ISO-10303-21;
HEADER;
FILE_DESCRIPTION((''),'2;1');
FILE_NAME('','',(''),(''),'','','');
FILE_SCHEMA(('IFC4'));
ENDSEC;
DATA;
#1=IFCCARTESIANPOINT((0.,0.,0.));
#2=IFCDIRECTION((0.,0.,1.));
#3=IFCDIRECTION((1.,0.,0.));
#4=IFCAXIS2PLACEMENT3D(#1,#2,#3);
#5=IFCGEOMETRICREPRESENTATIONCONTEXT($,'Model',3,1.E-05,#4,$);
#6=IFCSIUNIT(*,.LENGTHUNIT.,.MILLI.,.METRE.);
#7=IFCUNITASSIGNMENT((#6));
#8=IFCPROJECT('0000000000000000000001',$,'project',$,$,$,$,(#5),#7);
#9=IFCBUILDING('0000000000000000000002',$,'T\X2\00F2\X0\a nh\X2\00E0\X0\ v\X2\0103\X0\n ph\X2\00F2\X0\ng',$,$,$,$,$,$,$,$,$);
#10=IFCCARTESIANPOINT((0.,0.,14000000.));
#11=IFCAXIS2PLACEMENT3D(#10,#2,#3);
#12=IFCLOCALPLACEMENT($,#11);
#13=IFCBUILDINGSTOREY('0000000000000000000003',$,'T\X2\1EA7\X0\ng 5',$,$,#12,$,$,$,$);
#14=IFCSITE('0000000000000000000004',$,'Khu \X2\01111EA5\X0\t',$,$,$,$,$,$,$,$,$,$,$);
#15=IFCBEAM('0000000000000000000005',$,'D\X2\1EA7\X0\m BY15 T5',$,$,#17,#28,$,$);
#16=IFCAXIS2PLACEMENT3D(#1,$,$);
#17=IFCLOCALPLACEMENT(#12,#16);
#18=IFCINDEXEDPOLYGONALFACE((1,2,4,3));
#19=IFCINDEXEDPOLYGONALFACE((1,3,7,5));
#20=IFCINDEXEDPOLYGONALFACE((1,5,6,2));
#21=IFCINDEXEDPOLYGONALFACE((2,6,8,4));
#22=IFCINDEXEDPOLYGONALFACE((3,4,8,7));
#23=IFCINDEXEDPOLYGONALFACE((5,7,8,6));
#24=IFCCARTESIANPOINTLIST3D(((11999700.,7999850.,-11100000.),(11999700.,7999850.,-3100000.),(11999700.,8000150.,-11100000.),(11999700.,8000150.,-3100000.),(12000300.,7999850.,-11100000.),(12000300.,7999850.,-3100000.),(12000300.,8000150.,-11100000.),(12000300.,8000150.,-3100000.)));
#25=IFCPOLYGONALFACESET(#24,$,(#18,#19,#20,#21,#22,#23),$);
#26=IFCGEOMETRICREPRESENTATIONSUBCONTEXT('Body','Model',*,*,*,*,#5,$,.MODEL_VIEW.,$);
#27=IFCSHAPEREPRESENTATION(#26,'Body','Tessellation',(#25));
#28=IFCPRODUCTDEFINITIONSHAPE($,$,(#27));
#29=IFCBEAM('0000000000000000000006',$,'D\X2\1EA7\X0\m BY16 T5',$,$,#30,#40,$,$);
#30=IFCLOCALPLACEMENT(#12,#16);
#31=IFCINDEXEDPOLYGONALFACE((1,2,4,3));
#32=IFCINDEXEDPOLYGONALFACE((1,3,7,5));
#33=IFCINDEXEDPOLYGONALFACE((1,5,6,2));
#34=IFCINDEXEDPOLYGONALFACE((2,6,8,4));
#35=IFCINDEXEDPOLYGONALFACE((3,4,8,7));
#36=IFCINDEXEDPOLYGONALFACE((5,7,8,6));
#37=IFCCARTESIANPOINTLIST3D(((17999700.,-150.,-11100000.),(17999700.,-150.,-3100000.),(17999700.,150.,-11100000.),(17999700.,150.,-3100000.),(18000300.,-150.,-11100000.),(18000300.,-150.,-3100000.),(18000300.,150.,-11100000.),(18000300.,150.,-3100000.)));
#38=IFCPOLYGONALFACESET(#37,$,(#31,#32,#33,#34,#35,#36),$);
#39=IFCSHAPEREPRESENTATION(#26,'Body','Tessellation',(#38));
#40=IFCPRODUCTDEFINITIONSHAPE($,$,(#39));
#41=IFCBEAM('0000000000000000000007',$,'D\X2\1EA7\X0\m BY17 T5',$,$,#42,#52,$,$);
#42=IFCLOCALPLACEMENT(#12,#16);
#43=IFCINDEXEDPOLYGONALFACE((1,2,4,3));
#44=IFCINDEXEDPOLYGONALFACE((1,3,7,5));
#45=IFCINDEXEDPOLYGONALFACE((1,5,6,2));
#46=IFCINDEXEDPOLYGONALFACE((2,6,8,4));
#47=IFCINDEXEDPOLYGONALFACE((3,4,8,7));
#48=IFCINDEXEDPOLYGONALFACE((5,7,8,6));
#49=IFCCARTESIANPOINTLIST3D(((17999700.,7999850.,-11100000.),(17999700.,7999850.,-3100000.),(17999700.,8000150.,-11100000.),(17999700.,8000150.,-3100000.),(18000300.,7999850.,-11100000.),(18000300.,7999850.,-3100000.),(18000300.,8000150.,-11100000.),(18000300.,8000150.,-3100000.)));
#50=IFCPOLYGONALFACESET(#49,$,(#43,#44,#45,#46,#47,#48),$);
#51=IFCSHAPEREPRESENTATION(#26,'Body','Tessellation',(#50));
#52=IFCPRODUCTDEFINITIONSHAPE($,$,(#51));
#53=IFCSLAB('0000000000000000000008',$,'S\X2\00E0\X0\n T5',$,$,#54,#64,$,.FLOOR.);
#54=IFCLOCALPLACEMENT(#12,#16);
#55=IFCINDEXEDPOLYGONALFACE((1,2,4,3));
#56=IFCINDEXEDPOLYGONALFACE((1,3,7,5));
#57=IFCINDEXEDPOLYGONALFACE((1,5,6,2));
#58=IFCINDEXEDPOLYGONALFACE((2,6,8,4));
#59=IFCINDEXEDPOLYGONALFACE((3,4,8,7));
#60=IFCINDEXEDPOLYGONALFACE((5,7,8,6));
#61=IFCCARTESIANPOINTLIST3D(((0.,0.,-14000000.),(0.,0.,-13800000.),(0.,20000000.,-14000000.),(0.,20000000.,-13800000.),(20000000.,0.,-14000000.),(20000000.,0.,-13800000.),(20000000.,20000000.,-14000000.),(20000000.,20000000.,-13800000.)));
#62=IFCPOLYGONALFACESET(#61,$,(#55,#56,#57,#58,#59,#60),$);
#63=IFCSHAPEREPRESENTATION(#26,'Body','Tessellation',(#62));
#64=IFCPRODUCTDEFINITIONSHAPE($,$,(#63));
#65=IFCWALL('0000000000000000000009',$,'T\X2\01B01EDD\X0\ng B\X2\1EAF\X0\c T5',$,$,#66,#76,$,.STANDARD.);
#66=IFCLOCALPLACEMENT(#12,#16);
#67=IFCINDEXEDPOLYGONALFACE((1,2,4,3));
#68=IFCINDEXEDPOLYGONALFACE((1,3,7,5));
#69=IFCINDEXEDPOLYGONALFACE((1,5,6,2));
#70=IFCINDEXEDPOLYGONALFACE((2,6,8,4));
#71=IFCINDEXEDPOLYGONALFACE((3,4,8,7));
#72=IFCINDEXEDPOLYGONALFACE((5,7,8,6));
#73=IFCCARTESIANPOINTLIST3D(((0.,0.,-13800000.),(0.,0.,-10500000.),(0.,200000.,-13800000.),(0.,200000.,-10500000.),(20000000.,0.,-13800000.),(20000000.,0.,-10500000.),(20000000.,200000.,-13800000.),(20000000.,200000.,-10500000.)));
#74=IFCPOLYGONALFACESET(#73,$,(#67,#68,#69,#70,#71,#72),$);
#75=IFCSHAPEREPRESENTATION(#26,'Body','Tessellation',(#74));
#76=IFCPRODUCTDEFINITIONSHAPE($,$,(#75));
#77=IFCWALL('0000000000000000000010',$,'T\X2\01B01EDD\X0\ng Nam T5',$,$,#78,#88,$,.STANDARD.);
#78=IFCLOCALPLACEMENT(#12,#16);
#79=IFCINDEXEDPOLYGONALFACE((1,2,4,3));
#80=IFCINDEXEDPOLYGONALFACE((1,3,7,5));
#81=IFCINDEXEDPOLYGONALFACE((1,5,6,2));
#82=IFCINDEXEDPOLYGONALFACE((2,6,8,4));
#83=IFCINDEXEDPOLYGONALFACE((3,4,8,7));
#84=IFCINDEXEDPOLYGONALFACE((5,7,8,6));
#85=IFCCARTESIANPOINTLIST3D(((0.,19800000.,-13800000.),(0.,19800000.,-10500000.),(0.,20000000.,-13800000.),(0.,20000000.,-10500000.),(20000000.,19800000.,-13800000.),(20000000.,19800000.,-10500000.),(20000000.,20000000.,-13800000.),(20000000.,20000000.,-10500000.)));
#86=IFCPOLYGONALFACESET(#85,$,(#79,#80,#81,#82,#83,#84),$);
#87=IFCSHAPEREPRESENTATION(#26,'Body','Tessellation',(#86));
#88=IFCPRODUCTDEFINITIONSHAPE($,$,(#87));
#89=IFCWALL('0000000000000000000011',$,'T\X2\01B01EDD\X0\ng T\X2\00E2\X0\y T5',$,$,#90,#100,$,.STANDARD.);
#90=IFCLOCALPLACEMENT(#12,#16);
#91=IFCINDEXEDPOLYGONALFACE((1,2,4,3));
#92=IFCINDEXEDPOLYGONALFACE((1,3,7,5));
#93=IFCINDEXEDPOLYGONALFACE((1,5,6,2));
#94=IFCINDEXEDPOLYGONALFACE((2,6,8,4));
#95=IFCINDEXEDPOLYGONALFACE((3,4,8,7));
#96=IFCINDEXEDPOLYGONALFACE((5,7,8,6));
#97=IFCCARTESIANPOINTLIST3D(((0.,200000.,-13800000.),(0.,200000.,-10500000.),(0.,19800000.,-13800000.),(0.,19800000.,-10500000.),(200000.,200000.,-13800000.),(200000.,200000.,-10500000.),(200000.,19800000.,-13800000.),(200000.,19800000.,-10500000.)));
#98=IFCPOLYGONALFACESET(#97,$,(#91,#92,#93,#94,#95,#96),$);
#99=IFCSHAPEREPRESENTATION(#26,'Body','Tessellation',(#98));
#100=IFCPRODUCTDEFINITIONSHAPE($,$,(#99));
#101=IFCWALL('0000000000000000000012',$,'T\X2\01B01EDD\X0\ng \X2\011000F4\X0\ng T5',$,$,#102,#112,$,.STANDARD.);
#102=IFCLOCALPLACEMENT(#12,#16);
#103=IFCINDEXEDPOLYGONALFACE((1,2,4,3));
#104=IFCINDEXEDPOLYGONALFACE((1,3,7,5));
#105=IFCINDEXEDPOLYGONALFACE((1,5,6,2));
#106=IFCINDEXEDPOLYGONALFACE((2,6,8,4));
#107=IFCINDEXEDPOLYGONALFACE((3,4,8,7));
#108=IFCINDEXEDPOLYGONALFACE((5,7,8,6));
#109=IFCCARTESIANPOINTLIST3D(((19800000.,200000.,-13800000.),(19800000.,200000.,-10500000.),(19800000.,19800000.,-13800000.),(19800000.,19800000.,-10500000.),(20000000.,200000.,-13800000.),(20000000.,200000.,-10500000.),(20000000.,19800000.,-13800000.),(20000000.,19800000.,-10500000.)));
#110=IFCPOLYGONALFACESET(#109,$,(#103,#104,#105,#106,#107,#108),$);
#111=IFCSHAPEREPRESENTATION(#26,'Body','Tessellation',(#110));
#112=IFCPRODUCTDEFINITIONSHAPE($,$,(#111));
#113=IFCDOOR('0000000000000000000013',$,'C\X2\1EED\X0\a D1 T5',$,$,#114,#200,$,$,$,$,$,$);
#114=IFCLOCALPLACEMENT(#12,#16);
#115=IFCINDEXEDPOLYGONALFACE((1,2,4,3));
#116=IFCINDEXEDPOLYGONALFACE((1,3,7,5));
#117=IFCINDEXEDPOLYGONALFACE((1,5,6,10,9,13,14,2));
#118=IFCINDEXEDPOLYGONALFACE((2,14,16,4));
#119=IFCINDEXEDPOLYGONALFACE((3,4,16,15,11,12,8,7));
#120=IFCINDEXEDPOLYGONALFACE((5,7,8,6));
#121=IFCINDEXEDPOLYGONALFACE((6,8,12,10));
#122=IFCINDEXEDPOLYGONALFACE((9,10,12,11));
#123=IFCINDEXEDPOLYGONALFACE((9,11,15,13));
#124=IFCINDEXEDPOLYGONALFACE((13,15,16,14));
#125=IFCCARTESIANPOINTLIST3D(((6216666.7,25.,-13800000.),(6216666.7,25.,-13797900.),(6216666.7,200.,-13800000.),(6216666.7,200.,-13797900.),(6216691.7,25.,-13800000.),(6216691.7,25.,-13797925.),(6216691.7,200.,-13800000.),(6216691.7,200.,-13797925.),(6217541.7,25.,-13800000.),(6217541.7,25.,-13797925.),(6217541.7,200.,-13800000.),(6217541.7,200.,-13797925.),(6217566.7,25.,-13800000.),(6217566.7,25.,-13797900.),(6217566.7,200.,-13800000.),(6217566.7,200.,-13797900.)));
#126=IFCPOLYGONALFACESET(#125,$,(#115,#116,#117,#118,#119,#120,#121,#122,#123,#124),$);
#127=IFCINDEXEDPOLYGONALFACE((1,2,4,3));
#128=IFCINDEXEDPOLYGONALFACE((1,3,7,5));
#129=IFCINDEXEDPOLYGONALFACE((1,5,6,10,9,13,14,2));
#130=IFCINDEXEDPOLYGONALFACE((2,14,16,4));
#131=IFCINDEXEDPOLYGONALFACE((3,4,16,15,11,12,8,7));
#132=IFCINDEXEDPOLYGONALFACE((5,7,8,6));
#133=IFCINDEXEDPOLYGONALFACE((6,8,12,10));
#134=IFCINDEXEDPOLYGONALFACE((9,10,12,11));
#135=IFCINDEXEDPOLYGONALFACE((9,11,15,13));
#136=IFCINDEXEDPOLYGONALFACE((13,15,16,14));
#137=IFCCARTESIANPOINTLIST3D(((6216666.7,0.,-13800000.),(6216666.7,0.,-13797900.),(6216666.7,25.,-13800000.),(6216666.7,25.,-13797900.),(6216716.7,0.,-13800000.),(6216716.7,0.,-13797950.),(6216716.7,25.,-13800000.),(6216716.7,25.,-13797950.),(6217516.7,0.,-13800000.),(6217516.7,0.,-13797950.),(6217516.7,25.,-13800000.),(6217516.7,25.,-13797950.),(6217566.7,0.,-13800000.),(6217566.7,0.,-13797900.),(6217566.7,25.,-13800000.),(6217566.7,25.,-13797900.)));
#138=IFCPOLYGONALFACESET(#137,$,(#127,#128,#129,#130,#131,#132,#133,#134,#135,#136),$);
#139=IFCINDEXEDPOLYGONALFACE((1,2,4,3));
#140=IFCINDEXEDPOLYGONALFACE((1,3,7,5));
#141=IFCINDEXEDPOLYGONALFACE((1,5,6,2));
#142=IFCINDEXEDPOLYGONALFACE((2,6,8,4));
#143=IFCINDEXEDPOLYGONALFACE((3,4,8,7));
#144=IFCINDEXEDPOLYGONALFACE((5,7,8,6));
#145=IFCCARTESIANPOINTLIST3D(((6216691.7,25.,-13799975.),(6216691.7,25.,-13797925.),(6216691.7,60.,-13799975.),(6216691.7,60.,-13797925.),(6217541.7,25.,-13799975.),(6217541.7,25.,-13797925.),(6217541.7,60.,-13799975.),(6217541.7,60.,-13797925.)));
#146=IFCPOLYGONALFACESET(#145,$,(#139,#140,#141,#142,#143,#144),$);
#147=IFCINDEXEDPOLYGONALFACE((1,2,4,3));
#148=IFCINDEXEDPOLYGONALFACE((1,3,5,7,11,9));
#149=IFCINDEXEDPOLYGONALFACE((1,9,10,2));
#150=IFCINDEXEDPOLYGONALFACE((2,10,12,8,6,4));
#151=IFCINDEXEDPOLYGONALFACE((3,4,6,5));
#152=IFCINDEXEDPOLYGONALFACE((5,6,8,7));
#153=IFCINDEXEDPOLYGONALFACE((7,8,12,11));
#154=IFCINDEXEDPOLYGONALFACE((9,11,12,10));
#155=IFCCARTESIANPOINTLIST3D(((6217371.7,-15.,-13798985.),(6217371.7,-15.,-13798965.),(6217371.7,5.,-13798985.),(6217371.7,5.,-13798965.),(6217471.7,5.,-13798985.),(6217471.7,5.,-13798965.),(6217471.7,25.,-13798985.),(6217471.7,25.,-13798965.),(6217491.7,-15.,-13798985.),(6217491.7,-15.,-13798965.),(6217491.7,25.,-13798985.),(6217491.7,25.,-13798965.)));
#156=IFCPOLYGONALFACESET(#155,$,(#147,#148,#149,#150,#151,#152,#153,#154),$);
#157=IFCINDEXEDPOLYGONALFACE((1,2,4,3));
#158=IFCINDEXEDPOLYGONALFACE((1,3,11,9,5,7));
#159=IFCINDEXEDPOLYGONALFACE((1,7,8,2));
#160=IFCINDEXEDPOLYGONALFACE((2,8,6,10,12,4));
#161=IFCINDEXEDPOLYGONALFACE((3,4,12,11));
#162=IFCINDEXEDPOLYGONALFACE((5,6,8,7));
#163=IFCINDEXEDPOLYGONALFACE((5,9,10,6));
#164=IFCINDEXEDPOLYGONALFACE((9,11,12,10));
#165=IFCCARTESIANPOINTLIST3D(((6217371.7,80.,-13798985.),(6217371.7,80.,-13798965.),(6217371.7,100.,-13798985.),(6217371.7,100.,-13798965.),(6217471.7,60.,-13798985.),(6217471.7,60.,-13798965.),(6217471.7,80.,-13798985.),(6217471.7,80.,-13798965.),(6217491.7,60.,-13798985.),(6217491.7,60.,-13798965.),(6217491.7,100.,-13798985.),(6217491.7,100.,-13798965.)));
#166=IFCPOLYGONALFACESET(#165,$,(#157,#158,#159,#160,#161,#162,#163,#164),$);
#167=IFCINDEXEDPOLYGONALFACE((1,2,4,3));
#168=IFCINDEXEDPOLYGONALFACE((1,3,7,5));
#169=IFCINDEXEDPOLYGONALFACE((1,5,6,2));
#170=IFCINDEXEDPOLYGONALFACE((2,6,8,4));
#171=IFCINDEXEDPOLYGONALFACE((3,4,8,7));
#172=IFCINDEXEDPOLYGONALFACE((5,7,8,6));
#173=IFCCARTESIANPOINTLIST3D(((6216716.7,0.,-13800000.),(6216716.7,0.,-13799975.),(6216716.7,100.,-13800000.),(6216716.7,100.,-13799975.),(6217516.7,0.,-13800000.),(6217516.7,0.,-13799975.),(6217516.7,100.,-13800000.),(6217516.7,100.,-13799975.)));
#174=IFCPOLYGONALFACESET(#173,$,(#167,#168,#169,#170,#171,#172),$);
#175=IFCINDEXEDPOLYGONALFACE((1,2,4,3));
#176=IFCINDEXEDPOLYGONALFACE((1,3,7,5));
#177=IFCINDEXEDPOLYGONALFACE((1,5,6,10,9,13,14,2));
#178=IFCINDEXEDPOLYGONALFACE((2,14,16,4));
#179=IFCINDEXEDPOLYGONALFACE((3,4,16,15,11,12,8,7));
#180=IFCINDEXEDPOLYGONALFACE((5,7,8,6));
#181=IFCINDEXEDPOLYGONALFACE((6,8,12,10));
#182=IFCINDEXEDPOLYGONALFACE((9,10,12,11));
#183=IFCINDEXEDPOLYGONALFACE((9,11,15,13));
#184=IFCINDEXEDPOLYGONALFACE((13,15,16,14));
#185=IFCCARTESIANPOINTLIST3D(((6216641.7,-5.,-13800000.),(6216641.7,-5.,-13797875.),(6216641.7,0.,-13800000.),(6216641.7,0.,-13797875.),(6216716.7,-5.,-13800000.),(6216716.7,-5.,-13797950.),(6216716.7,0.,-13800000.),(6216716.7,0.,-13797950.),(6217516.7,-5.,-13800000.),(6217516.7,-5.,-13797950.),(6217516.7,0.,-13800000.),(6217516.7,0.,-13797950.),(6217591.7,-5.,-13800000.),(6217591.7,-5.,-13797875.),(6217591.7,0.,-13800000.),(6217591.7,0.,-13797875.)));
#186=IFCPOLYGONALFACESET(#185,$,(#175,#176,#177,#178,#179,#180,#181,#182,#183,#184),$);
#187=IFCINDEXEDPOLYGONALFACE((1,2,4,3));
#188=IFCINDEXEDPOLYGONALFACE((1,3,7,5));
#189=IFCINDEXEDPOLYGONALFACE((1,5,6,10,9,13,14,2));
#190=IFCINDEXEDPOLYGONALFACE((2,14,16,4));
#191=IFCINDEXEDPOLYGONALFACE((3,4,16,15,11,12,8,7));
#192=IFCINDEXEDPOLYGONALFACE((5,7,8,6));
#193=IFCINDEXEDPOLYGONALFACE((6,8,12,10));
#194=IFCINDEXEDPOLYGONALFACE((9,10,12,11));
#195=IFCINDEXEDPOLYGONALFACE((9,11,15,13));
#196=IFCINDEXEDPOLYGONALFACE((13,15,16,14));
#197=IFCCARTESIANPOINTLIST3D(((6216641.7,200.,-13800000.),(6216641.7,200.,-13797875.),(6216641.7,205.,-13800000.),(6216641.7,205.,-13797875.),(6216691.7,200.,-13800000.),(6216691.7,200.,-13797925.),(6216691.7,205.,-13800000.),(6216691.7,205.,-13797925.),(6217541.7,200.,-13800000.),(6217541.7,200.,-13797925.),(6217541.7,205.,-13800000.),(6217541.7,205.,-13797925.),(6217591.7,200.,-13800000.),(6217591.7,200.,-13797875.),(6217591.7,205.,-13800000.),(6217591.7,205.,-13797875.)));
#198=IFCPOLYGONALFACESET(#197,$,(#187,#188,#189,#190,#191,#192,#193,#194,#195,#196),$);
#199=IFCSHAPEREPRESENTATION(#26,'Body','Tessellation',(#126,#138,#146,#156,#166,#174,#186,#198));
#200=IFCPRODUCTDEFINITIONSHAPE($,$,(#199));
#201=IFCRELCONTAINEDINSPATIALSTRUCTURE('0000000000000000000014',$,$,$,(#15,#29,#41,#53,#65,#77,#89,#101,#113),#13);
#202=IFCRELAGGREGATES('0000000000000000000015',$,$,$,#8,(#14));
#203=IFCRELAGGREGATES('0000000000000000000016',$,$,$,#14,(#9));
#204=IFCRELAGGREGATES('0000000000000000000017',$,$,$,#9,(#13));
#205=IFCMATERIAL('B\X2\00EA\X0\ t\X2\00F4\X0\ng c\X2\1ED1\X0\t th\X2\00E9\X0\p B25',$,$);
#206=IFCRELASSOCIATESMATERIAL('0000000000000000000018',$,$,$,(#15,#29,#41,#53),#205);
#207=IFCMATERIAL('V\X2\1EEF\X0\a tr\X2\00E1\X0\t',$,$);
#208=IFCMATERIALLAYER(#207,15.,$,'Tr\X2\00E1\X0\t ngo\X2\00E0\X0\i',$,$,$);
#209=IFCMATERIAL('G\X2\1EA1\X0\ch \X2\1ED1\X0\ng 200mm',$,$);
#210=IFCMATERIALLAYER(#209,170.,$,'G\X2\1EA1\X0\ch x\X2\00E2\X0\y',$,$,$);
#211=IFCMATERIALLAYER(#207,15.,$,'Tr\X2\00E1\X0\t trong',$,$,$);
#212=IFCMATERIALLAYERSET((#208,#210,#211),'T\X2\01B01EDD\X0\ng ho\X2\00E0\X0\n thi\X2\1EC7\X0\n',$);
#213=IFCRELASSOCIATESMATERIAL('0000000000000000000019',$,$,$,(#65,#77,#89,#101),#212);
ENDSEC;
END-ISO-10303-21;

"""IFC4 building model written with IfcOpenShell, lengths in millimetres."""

from ifc_helpers import new_model, entity, si_unit, frame, origin_with_axes, place, context, subcontext, project, spatial, line, indexed_curve, outline, extrude, material, layer, layer_set, layer_usage, element, save


model = new_model("IFC4")

# Units and contexts
model_context = context("Model", 3, precision=1e-05, world=origin_with_axes())
body_context = subcontext(model_context, "Body", "Model", "MODEL_VIEW")
ifc_project = project(units=[si_unit("LENGTHUNIT", "METRE", prefix="MILLI")], contexts=[model_context])

# Site, building, storey
site = spatial("IfcSite", under=ifc_project, Name="Khu đất")
building = spatial("IfcBuilding", under=site, Name="Tòa nhà văn phòng")
storey_placement = place(None, frame((0.0, 0.0, 14000000.0), z_axis=(0.0, 0.0, 1.0), x_axis=(1.0, 0.0, 0.0)))
storey = spatial("IfcBuildingStorey", under=building, at=storey_placement, Name="Tầng 5")

# Shared definitions
ifc_material_1 = material(Name="Bê tông cốt thép B25")

# Beams
for number, where, z_axis, x_axis, name in (
    (1, (12000000.0, 8000000.0, -11100000.0), (0.0, 0.0, 1.0), (0.0, 1.0, 0.0), "Dầm BY15 T5"),
    (2, (18000000.0, 0.0, -11100000.0), (0.0, 0.0, 1.0), (0.0, 1.0, 0.0), "Dầm BY16 T5"),
    (3, (18000000.0, 8000000.0, -11100000.0), (0.0, 0.0, 1.0), (0.0, 1.0, 0.0), "Dầm BY17 T5"),
):
    element("IfcBeam", number, at=place(storey_placement, frame(where, z_axis=z_axis, x_axis=x_axis)), inside=storey, material=ifc_material_1, Name=name, context=body_context, shape_type="SweptSolid", body=[
        extrude(entity("IfcRectangleProfileDef", None, None, None, 300.0, 600.0), origin_with_axes(), (0.0, 0.0, 1.0), 8000000.0),
    ])

# Slab
slab_placement = place(storey_placement, frame((0.0, 0.0, -14000000.0), z_axis=(0.0, 0.0, 1.0), x_axis=(1.0, 0.0, 0.0)))
element("IfcSlab", 4, at=slab_placement, inside=storey, material=ifc_material_1, Name="Sàn T5", PredefinedType="FLOOR", context=body_context, shape_type="SweptSolid", body=[
    extrude(outline(indexed_curve([(0.0, 0.0), (20000000.0, 0.0), (20000000.0, 20000000.0), (0.0, 20000000.0), (0.0, 0.0)])), None, (0.0, 0.0, 1.0), 200000.0),
])

# Walls
ifc_material_2 = material(Name="Vữa trát")
ifc_layer_1 = layer(ifc_material_2, 15.0, Name="Trát ngoài")
ifc_material_3 = material(Name="Gạch ống 200mm")
ifc_layer_2 = layer(ifc_material_3, 170.0, Name="Gạch xây")
ifc_layer_3 = layer(ifc_material_2, 15.0, Name="Trát trong")
ifc_layer_set = layer_set([ifc_layer_1, ifc_layer_2, ifc_layer_3], Name="Tường hoàn thiện")
ifc_layer_usage_1 = layer_usage(ifc_layer_set, "AXIS2", "POSITIVE", 0.0)
wall_1_placement = place(storey_placement, frame((0.0, 0.0, -13800000.0), z_axis=(0.0, 0.0, 1.0), x_axis=(1.0, 0.0, 0.0)))
element("IfcWall", 5, at=wall_1_placement, inside=storey, material=ifc_layer_usage_1, Name="Tường Bắc T5", PredefinedType="STANDARD", context=body_context, shape_type="SweptSolid", body=[
    extrude(outline(indexed_curve([(0.0, 0.0), (0.0, 200000.0), (20000000.0, 200000.0), (20000000.0, 0.0), (0.0, 0.0)], self_intersect=False)), origin_with_axes(), (0.0, 0.0, 1.0), 3300000.0),
])
ifc_layer_usage_2 = layer_usage(ifc_layer_set, "AXIS2", "POSITIVE", 0.0)
wall_2_placement = place(storey_placement, frame((0.0, 19800000.0, -13800000.0), z_axis=(0.0, 0.0, 1.0), x_axis=(1.0, 0.0, 0.0)))
element("IfcWall", 6, at=wall_2_placement, inside=storey, material=ifc_layer_usage_2, Name="Tường Nam T5", PredefinedType="STANDARD", context=body_context, shape_type="SweptSolid", body=[
    extrude(outline(indexed_curve([(0.0, 0.0), (0.0, 200000.0), (20000000.0, 200000.0), (20000000.0, 0.0), (0.0, 0.0)], self_intersect=False)), origin_with_axes(), (0.0, 0.0, 1.0), 3300000.0),
])
ifc_layer_usage_3 = layer_usage(ifc_layer_set, "AXIS2", "POSITIVE", 0.0)
wall_3_placement = place(storey_placement, frame((0.0, 200000.0, -13800000.0), z_axis=(0.0, 0.0, 1.0), x_axis=(1.0, 0.0, 0.0)))
element("IfcWall", 7, at=wall_3_placement, inside=storey, material=ifc_layer_usage_3, Name="Tường Tây T5", PredefinedType="STANDARD", context=body_context, shape_type="SweptSolid", body=[
    extrude(outline(indexed_curve([(0.0, 0.0), (0.0, 19600000.0), (200000.0, 19600000.0), (200000.0, 0.0), (0.0, 0.0)], self_intersect=False)), origin_with_axes(), (0.0, 0.0, 1.0), 3300000.0),
])
ifc_layer_usage_4 = layer_usage(ifc_layer_set, "AXIS2", "POSITIVE", 0.0)
wall_4_placement = place(storey_placement, frame((19800000.0, 200000.0, -13800000.0), z_axis=(0.0, 0.0, 1.0), x_axis=(1.0, 0.0, 0.0)))
element("IfcWall", 8, at=wall_4_placement, inside=storey, material=ifc_layer_usage_4, Name="Tường Đông T5", PredefinedType="STANDARD", context=body_context, shape_type="SweptSolid", body=[
    extrude(outline(indexed_curve([(0.0, 0.0), (0.0, 19600000.0), (200000.0, 19600000.0), (200000.0, 0.0), (0.0, 0.0)], self_intersect=False)), origin_with_axes(), (0.0, 0.0, 1.0), 3300000.0),
])

# Door
door_1_placement = place(storey_placement, frame((6216666.7, 0.0, -13800000.0), z_axis=(0.0, 0.0, 1.0), x_axis=(1.0, 0.0, 0.0)))
element("IfcDoor", 9, at=door_1_placement, inside=storey, Name="Cửa D1 T5", context=body_context, shape_type="SolidModel", body=[
    extrude(outline(indexed_curve([(0.0, 0.0), (0.0, 2100.0), (900.0, 2100.0), (900.0, 0.0), (875.0, 0.0), (875.0, 2075.0), (25.0, 2075.0), (25.0, 0.0)], segments=[line(1, 2, 3, 4, 5, 6, 7, 8, 1)])), frame((0.0, 25.0, 0.0), z_axis=(0.0, -1.0, 0.0), x_axis=(1.0, 0.0, 0.0)), (0.0, 0.0, -1.0), 175.0),
    extrude(outline(indexed_curve([(0.0, 0.0), (0.0, 2100.0), (900.0, 2100.0), (900.0, 0.0), (850.0, 0.0), (850.0, 2050.0), (50.0, 2050.0), (50.0, 0.0)], segments=[line(1, 2, 3, 4, 5, 6, 7, 8, 1)])), frame((0.0, 0.0, 0.0), z_axis=(0.0, -1.0, 0.0), x_axis=(1.0, 0.0, 0.0)), (0.0, 0.0, -1.0), 25.0),
    extrude(outline(indexed_curve([(0.0, 0.0), (850.0, 0.0), (850.0, 35.0), (0.0, 35.0)], segments=[line(1, 2, 3, 4, 1)])), frame((25.0, 25.0, 25.0), z_axis=(0.0, 0.0, 1.0), x_axis=(1.0, 0.0, 0.0)), (0.0, 0.0, 1.0), 2050.0),
    extrude(outline(indexed_curve([(0.0, 0.0), (0.0, -40.0), (-120.0, -40.0), (-120.0, -20.0), (-20.0, -20.0), (-20.0, 0.0)], segments=[line(1, 2, 3, 4, 5, 6, 1)])), frame((825.0, 25.0, 1015.0), z_axis=(0.0, 0.0, 1.0), x_axis=(1.0, 0.0, 0.0)), (0.0, 0.0, 1.0), 20.0),
    extrude(outline(indexed_curve([(0.0, 0.0), (0.0, 40.0), (-120.0, 40.0), (-120.0, 20.0), (-20.0, 20.0), (-20.0, 0.0)], segments=[line(1, 2, 3, 4, 5, 6, 1)])), frame((825.0, 60.0, 1015.0), z_axis=(0.0, 0.0, 1.0), x_axis=(1.0, 0.0, 0.0)), (0.0, 0.0, 1.0), 20.0),
    extrude(outline(indexed_curve([(0.0, 0.0), (800.0, 0.0), (800.0, 100.0), (0.0, 100.0)], segments=[line(1, 2, 3, 4, 1)])), frame((50.0, 0.0, 0.0), z_axis=(0.0, 0.0, 1.0), x_axis=(1.0, 0.0, 0.0)), (0.0, 0.0, 1.0), 25.0),
    extrude(outline(indexed_curve([(0.0, 0.0), (0.0, 2125.0), (950.0, 2125.0), (950.0, 0.0), (875.0, 0.0), (875.0, 2050.0), (75.0, 2050.0), (75.0, 0.0)], segments=[line(1, 2, 3, 4, 5, 6, 7, 8, 1)])), frame((-25.0, -5.0, 0.0), z_axis=(0.0, -1.0, 0.0), x_axis=(1.0, 0.0, 0.0)), (0.0, 0.0, -1.0), 5.0),
    extrude(outline(indexed_curve([(0.0, 0.0), (0.0, 2125.0), (950.0, 2125.0), (950.0, 0.0), (900.0, 0.0), (900.0, 2075.0), (50.0, 2075.0), (50.0, 0.0)], segments=[line(1, 2, 3, 4, 5, 6, 7, 8, 1)])), frame((-25.0, 200.0, 0.0), z_axis=(0.0, -1.0, 0.0), x_axis=(1.0, 0.0, 0.0)), (0.0, 0.0, -1.0), 5.0),
])

save(model, "model.ifc")
